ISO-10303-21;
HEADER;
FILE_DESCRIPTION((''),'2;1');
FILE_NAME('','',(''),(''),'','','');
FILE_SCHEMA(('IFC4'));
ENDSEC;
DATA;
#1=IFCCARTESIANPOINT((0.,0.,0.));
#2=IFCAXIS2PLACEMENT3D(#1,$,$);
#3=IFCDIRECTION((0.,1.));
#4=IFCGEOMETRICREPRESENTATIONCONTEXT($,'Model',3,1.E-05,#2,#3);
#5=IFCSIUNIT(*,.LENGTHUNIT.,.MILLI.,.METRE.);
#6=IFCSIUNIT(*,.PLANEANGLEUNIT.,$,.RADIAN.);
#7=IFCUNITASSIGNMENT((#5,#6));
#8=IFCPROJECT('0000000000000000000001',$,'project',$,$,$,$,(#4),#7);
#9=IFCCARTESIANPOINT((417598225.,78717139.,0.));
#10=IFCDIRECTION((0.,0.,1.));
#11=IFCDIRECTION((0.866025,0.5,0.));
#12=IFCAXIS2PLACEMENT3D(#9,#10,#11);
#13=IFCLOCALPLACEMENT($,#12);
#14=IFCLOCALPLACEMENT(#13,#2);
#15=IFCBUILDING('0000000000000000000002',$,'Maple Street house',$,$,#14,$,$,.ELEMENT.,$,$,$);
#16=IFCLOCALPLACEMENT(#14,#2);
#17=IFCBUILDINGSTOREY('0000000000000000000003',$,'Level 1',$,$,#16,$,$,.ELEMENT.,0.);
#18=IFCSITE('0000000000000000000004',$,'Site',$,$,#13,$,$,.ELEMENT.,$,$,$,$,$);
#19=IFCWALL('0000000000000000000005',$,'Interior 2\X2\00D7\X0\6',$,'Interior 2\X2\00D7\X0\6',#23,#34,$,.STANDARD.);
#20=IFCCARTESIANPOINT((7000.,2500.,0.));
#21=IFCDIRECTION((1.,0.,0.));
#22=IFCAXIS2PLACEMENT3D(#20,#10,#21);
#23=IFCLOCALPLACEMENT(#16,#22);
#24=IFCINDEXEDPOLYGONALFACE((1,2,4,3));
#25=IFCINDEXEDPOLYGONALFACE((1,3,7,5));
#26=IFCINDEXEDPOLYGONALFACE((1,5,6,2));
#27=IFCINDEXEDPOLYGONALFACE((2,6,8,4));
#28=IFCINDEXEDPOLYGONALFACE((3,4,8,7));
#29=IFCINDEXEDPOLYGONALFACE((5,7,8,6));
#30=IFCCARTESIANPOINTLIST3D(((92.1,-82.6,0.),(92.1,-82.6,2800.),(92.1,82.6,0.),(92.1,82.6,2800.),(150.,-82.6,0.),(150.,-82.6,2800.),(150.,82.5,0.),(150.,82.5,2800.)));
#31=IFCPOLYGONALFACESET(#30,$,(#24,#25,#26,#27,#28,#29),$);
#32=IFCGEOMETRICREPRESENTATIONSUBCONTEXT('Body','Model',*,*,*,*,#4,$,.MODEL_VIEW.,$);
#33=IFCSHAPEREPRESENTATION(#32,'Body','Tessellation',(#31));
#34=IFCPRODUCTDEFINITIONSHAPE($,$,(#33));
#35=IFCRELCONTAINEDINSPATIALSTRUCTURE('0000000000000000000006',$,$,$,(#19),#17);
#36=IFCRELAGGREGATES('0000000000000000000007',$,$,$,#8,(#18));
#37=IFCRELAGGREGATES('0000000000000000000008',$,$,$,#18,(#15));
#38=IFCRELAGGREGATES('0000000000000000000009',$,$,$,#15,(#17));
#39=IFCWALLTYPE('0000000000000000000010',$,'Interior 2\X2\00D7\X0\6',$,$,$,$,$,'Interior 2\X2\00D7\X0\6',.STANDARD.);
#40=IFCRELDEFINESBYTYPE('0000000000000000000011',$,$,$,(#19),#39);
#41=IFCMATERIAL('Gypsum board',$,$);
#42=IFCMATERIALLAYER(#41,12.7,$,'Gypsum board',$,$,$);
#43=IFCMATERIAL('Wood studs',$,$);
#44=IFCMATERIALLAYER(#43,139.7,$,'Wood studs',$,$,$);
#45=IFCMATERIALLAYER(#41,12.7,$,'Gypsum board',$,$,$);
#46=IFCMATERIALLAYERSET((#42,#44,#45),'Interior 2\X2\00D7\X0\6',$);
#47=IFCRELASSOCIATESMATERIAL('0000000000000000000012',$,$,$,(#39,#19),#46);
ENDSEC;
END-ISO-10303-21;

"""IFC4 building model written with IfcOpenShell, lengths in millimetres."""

from ifc_helpers import new_model, si_unit, direction, frame, origin, place, context, subcontext, project, spatial, polyline, outline, extrude, material, layer, layer_set, layer_usage, type_object, element, save


model = new_model("IFC4")

# Units and contexts
model_context = context("Model", 3, precision=1e-05, world=origin(), true_north=direction((0.0, 1.0)))
body_context = subcontext(model_context, "Body", "Model", "MODEL_VIEW")
ifc_project = project(units=[si_unit("LENGTHUNIT", "METRE", prefix="MILLI"), si_unit("PLANEANGLEUNIT", "RADIAN")], contexts=[model_context])

# Site, building, storey
site_placement = place(None, frame((417598225.0, 78717139.0, 0.0), z_axis=(0.0, 0.0, 1.0), x_axis=(0.866025, 0.5, 0.0)))
site = spatial("IfcSite", under=ifc_project, at=site_placement, Name="Site", CompositionType="ELEMENT")
building_placement = place(site_placement, origin())
building = spatial("IfcBuilding", under=site, at=building_placement, Name="Maple Street house", CompositionType="ELEMENT")
storey_placement = place(building_placement, origin())
storey = spatial("IfcBuildingStorey", under=building, at=storey_placement, Name="Level 1", CompositionType="ELEMENT", Elevation=0.0)

# Shared definitions
ifc_material_1 = material(Name="Wood studs")
ifc_material_2 = material(Name="Gypsum board")

# Wall
ifc_layer_1 = layer(ifc_material_2, 12.7, Name="Gypsum board")
ifc_layer_2 = layer(ifc_material_1, 139.7, Name="Wood studs")
ifc_layer_3 = layer(ifc_material_2, 12.7, Name="Gypsum board")
ifc_layer_set_1 = layer_set([ifc_layer_1, ifc_layer_2, ifc_layer_3], Name="Interior 2×6")
ifc_layer_usage_1 = layer_usage(ifc_layer_set_1, "AXIS2", "NEGATIVE", 82.5)
wall_type_1 = type_object("IfcWallType", Name="Interior 2×6", ElementType="Interior 2×6", PredefinedType="STANDARD", material=ifc_layer_set_1)
wall_1_placement = place(storey_placement, frame((7000.0, 2500.0, 0.0), z_axis=(0.0, 0.0, 1.0), x_axis=(1.0, 0.0, 0.0)))
element("IfcWall", 1, at=wall_1_placement, inside=storey, type_object=wall_type_1, material=ifc_layer_usage_1, Name="Interior 2×6", ObjectType="Interior 2×6", PredefinedType="STANDARD", context=body_context, shape_type="SweptSolid", body=[
    extrude(outline(polyline([(92.1, -82.5), (150.0, -82.5), (150.0, 82.5), (92.1, 82.5), (92.1, -82.5)])), origin(), (0.0, 0.0, 1.0), 2800.0),
])

save(model, "model.ifc")
